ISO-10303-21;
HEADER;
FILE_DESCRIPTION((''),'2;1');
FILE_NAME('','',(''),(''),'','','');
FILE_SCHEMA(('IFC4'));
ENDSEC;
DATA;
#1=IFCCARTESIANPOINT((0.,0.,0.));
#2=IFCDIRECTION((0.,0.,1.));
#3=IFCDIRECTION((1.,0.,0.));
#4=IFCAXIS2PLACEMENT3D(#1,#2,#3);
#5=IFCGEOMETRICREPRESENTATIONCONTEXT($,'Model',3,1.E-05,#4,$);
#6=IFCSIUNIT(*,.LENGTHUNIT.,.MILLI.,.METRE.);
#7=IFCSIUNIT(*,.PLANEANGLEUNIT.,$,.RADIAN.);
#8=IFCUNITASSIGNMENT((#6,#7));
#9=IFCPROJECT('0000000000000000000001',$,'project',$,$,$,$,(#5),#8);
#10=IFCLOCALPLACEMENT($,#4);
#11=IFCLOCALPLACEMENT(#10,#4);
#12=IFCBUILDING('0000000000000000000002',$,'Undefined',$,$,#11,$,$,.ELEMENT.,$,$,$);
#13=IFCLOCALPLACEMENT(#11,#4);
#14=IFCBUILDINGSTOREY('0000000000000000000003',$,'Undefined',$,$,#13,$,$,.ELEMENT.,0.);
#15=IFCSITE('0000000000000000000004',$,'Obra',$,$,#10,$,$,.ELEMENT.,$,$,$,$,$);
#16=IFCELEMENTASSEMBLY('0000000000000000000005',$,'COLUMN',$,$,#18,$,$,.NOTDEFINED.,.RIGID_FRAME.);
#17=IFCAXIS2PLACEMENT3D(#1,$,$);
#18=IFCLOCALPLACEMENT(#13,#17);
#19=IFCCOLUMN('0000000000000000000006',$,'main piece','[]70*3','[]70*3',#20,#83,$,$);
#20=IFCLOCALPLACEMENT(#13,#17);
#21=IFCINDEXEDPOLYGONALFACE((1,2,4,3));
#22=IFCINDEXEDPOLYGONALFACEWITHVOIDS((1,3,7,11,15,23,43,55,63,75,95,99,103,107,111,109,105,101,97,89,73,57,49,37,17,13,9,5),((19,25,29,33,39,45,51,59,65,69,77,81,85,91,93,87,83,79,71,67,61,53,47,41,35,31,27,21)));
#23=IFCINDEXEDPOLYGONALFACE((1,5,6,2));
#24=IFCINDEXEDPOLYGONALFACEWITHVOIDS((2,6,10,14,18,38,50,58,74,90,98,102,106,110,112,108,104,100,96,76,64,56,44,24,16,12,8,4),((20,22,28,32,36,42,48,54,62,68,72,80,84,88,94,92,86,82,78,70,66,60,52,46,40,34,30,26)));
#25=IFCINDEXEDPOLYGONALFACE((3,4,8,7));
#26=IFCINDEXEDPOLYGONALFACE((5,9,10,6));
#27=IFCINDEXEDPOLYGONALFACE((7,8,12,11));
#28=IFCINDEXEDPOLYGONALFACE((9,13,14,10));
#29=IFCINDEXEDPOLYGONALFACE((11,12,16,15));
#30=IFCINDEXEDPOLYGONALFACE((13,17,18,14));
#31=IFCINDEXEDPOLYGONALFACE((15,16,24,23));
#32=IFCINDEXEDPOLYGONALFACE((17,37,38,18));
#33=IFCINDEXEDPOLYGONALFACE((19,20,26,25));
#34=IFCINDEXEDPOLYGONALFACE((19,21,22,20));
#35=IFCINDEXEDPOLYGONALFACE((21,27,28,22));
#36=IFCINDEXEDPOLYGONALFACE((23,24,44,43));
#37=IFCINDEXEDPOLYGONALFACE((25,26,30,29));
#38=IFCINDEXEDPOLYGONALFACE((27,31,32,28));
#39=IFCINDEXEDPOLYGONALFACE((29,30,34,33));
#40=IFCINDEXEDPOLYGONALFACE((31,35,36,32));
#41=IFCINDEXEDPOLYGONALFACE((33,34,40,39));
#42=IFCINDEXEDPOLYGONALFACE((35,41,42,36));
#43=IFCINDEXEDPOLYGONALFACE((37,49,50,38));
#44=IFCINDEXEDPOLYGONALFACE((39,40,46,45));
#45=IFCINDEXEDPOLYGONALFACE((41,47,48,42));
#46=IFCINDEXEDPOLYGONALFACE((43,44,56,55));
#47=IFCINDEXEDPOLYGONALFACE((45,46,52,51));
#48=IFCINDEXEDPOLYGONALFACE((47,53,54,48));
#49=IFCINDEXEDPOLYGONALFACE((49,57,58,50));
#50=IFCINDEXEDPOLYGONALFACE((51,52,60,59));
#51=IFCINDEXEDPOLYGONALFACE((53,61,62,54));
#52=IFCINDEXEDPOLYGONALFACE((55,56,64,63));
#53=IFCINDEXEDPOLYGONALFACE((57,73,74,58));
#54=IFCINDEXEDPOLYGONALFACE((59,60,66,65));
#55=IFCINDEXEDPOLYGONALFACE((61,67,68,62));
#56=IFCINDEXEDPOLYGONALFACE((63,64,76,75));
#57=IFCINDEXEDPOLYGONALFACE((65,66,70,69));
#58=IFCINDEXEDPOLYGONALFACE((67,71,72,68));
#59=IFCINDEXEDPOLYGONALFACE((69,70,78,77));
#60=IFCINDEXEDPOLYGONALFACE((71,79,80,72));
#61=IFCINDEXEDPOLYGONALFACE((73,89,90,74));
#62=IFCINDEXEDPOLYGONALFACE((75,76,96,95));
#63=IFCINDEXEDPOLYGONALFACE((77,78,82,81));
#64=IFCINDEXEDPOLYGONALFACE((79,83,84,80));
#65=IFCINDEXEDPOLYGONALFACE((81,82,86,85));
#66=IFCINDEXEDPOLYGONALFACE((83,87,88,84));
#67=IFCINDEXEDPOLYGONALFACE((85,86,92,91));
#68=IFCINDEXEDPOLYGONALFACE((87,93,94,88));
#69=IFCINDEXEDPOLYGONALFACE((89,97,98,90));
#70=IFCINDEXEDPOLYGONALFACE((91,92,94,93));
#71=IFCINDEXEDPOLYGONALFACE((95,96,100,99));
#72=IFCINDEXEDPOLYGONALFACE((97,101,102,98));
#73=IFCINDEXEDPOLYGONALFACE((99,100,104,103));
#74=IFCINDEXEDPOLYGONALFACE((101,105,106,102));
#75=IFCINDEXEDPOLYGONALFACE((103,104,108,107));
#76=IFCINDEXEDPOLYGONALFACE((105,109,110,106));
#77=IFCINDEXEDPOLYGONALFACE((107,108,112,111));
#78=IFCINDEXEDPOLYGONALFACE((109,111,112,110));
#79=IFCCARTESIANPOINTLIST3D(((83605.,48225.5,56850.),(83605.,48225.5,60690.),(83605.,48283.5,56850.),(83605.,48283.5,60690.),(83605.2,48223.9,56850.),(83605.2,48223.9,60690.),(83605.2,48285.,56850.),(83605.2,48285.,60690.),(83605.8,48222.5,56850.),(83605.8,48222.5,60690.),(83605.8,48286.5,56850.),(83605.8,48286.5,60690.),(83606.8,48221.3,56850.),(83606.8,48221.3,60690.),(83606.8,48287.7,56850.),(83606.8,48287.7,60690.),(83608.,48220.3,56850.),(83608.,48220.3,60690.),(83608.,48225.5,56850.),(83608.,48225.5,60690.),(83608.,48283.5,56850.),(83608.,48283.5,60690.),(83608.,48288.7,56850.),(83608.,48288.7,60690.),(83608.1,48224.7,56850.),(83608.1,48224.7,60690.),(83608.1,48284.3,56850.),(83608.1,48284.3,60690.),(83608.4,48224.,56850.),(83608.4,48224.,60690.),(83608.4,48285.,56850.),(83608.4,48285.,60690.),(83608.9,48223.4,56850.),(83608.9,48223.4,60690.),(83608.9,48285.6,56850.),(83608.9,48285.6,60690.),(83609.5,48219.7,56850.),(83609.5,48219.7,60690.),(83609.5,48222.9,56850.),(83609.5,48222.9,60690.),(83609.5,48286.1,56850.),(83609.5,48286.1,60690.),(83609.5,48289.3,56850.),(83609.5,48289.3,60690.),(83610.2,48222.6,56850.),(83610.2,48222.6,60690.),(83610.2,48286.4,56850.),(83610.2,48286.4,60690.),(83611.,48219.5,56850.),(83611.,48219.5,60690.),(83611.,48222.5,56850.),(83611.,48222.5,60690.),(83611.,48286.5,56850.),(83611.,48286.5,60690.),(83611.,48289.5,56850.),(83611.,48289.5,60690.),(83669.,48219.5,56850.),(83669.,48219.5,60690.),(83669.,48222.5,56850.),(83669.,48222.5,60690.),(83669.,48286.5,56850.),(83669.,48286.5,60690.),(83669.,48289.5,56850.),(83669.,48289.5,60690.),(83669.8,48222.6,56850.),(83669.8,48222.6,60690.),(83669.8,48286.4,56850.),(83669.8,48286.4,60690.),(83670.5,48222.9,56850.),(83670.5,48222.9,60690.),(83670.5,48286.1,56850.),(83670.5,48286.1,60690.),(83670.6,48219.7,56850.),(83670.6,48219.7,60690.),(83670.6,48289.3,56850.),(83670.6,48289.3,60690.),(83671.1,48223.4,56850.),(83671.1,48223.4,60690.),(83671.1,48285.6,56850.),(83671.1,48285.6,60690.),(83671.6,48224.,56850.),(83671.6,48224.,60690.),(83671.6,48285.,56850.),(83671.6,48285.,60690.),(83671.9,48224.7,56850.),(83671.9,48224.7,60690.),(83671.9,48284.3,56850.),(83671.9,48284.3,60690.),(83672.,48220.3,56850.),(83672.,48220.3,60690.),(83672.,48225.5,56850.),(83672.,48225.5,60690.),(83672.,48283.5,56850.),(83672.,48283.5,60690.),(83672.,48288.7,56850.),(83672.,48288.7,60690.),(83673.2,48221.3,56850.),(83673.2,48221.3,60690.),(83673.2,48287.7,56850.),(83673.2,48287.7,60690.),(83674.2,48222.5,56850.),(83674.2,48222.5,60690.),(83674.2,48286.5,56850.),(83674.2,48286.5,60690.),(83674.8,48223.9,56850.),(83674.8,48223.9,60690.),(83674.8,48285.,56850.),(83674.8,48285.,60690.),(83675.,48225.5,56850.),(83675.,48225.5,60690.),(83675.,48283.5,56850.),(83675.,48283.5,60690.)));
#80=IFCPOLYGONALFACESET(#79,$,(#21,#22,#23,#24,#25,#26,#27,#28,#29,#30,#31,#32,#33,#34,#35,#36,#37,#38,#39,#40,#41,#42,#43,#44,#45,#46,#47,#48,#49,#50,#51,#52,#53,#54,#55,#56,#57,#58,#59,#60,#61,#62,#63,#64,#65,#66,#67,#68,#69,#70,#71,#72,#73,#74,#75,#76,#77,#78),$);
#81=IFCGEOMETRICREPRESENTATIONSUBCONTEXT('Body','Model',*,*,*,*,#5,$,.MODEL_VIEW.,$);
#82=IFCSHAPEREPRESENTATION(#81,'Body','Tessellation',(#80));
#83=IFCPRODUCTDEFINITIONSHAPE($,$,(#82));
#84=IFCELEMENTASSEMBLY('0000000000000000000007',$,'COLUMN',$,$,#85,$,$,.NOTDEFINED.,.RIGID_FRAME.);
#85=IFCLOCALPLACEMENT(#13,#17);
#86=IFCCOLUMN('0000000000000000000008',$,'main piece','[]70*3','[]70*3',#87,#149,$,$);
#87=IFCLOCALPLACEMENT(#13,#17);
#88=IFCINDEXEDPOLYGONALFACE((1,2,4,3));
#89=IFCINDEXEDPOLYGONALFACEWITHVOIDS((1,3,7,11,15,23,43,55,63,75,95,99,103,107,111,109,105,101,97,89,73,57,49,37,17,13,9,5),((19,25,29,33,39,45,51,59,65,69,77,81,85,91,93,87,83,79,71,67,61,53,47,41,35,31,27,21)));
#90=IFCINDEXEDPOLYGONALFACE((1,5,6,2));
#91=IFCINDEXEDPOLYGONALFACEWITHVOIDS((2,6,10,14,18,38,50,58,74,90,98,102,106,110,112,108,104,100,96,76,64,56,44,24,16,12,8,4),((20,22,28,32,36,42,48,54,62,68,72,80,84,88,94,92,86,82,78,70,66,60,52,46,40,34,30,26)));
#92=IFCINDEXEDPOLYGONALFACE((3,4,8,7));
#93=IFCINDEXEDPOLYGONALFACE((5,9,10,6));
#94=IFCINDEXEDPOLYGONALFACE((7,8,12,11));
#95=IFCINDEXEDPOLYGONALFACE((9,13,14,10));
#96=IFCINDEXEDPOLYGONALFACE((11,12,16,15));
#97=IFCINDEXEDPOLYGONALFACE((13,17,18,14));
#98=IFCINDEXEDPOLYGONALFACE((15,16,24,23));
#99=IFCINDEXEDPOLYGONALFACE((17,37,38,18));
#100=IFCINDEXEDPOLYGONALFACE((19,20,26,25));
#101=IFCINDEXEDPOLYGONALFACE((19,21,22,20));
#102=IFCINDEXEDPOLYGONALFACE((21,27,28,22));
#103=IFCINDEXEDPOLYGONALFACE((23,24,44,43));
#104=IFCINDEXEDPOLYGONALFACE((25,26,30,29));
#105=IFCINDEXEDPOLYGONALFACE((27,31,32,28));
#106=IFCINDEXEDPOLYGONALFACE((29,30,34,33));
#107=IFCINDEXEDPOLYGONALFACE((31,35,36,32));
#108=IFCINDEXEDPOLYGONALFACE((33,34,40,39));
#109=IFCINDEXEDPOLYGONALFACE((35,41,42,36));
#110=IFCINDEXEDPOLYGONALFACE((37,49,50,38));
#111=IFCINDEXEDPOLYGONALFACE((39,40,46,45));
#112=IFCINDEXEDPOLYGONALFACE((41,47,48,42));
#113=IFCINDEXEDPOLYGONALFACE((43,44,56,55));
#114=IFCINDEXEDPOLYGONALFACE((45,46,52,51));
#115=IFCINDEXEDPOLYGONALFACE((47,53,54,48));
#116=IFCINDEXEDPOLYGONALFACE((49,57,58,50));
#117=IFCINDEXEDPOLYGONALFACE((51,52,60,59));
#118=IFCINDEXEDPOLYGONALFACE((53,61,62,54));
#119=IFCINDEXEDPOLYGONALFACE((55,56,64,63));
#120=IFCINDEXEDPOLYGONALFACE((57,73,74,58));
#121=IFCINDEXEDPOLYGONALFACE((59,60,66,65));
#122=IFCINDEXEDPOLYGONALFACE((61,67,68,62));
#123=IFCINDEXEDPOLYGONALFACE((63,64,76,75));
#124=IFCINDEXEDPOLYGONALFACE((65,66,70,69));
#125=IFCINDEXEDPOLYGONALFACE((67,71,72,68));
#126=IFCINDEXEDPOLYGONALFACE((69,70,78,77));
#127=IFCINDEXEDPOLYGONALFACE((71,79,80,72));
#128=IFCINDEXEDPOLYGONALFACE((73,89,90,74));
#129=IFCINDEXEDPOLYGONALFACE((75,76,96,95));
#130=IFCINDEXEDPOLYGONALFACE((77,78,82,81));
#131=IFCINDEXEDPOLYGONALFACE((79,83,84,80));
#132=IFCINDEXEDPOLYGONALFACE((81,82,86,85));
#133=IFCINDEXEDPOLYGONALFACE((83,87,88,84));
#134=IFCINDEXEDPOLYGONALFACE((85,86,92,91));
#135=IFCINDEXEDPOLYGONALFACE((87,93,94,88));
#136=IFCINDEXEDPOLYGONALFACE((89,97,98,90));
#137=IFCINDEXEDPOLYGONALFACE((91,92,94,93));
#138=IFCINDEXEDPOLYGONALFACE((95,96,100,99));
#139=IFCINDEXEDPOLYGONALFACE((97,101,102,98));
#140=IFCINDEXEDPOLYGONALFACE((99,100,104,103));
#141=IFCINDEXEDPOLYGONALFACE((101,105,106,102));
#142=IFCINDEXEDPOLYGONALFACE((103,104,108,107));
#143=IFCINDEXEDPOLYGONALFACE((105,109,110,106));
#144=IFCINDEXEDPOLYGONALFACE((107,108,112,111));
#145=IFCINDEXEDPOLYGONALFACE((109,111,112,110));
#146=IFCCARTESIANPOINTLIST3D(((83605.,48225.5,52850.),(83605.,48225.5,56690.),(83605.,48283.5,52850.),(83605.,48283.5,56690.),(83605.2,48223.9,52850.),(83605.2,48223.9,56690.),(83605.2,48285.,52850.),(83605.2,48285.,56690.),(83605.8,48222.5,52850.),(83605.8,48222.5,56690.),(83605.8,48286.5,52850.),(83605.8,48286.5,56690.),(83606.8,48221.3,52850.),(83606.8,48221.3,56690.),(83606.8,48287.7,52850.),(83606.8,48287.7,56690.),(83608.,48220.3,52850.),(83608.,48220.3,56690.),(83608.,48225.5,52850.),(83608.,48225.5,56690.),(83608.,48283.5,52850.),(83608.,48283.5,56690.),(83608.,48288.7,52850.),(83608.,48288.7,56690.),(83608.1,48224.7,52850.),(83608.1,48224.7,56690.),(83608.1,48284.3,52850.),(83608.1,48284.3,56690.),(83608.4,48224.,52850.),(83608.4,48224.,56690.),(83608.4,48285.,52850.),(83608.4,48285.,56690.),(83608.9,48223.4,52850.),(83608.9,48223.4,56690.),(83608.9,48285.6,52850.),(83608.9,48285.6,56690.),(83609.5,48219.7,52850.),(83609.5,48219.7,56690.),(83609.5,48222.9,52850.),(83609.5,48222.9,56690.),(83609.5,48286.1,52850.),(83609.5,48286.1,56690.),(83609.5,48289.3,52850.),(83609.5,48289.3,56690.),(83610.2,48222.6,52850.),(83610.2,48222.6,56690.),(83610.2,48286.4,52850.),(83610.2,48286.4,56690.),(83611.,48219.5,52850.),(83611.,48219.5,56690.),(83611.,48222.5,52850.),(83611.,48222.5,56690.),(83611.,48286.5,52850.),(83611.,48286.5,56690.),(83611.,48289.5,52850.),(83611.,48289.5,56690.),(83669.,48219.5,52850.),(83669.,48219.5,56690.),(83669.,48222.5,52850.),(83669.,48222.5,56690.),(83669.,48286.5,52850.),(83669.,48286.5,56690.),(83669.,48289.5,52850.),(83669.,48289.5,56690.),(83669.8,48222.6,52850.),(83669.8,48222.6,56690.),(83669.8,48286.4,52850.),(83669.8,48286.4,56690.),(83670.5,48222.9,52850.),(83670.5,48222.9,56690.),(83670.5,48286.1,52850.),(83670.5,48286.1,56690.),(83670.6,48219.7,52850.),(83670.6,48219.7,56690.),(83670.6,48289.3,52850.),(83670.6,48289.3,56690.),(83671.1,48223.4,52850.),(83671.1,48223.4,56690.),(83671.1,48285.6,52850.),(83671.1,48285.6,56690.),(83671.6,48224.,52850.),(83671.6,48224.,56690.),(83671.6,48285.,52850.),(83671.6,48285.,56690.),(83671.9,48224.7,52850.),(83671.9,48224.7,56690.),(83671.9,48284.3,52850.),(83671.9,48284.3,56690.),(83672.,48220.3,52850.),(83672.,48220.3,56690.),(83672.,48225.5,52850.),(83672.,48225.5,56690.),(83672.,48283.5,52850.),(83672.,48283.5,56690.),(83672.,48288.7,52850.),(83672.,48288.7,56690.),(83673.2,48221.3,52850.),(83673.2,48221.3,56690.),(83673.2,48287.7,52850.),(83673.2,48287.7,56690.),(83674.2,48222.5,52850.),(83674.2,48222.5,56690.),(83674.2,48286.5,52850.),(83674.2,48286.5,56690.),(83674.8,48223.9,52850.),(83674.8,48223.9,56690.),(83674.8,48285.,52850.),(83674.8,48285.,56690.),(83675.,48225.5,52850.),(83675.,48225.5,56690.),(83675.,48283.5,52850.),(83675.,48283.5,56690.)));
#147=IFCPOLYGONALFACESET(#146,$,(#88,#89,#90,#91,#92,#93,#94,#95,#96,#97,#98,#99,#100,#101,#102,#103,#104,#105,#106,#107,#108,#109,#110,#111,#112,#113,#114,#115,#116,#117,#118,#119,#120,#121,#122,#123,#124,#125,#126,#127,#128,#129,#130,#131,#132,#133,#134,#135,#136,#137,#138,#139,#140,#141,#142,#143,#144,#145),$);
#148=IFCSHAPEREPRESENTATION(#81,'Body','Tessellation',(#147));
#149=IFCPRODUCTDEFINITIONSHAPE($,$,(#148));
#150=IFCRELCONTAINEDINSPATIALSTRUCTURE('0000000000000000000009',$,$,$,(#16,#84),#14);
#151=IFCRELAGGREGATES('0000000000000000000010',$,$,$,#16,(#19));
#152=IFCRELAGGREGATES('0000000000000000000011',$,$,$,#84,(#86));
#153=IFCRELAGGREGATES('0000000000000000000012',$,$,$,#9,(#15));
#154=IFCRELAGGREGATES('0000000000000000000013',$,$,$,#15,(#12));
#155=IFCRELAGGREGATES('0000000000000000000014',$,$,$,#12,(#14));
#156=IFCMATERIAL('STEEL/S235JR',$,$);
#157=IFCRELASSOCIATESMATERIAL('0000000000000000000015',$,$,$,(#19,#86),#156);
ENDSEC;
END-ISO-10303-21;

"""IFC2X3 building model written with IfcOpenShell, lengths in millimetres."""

from ifc_helpers import new_model, si_unit, frame, origin_with_axes, origin_2d_with_axis, place, context, subcontext, project, spatial, hollow_rectangle, extrude, material, element, aggregate, save


model = new_model("IFC2X3")

# Units and contexts
model_context = context("Model", 3, precision=1e-05, world=origin_with_axes())
body_context = subcontext(model_context, "Body", "Model", "MODEL_VIEW")
ifc_project = project(units=[si_unit("LENGTHUNIT", "METRE", prefix="MILLI"), si_unit("PLANEANGLEUNIT", "RADIAN")], contexts=[model_context])

# Site, building, storey
site_placement = place(None, origin_with_axes())
site = spatial("IfcSite", under=ifc_project, at=site_placement, Name="Obra", CompositionType="ELEMENT")
building_placement = place(site_placement, origin_with_axes())
building = spatial("IfcBuilding", under=site, at=building_placement, Name="Undefined", CompositionType="ELEMENT")
storey_placement = place(building_placement, origin_with_axes())
storey = spatial("IfcBuildingStorey", under=building, at=storey_placement, Name="Undefined", CompositionType="ELEMENT", Elevation=0.0)

# Element assemblies, columns
assembly_1_placement = place(storey_placement, origin_with_axes())
assembly_1 = element("IfcElementAssembly", 1, at=assembly_1_placement, inside=storey, Name="COLUMN", AssemblyPlace="NOTDEFINED", PredefinedType="RIGID_FRAME")
ifc_material = material(Name="STEEL/S235JR")
column_1_placement = place(assembly_1_placement, frame((83640.0, 48254.5, 56850.0), z_axis=(0.0, 0.0, 1.0), x_axis=(0.0, 1.0, 0.0)))
column_1 = element("IfcColumn", 2, at=column_1_placement, material=ifc_material, Name="main piece", Description="[]70*3", ObjectType="[]70*3", context=body_context, shape_type="SweptSolid", body=[
    extrude(hollow_rectangle(XDim=70.0, YDim=70.0, WallThickness=3.0, InnerFilletRadius=3.0, OuterFilletRadius=6.0, at=origin_2d_with_axis()), frame((0.0, 0.0, 3840.0), z_axis=(0.0, 0.0, -1.0), x_axis=(0.0, 1.0, 0.0)), (0.0, 0.0, 1.0), 3840.0),
])
aggregate(assembly_1, [column_1])
assembly_2_placement = place(storey_placement, origin_with_axes())
assembly_2 = element("IfcElementAssembly", 3, at=assembly_2_placement, inside=storey, Name="COLUMN", AssemblyPlace="NOTDEFINED", PredefinedType="RIGID_FRAME")
column_2_placement = place(assembly_2_placement, frame((83640.0, 48254.5, 52850.0), z_axis=(0.0, 0.0, 1.0), x_axis=(0.0, 1.0, 0.0)))
column_2 = element("IfcColumn", 4, at=column_2_placement, material=ifc_material, Name="main piece", Description="[]70*3", ObjectType="[]70*3", context=body_context, shape_type="SweptSolid", body=[
    extrude(hollow_rectangle(XDim=70.0, YDim=70.0, WallThickness=3.0, InnerFilletRadius=3.0, OuterFilletRadius=6.0, at=origin_2d_with_axis()), frame((0.0, 0.0, 3840.0), z_axis=(0.0, 0.0, -1.0), x_axis=(0.0, 1.0, 0.0)), (0.0, 0.0, 1.0), 3840.0),
])
aggregate(assembly_2, [column_2])

save(model, "model.ifc")
